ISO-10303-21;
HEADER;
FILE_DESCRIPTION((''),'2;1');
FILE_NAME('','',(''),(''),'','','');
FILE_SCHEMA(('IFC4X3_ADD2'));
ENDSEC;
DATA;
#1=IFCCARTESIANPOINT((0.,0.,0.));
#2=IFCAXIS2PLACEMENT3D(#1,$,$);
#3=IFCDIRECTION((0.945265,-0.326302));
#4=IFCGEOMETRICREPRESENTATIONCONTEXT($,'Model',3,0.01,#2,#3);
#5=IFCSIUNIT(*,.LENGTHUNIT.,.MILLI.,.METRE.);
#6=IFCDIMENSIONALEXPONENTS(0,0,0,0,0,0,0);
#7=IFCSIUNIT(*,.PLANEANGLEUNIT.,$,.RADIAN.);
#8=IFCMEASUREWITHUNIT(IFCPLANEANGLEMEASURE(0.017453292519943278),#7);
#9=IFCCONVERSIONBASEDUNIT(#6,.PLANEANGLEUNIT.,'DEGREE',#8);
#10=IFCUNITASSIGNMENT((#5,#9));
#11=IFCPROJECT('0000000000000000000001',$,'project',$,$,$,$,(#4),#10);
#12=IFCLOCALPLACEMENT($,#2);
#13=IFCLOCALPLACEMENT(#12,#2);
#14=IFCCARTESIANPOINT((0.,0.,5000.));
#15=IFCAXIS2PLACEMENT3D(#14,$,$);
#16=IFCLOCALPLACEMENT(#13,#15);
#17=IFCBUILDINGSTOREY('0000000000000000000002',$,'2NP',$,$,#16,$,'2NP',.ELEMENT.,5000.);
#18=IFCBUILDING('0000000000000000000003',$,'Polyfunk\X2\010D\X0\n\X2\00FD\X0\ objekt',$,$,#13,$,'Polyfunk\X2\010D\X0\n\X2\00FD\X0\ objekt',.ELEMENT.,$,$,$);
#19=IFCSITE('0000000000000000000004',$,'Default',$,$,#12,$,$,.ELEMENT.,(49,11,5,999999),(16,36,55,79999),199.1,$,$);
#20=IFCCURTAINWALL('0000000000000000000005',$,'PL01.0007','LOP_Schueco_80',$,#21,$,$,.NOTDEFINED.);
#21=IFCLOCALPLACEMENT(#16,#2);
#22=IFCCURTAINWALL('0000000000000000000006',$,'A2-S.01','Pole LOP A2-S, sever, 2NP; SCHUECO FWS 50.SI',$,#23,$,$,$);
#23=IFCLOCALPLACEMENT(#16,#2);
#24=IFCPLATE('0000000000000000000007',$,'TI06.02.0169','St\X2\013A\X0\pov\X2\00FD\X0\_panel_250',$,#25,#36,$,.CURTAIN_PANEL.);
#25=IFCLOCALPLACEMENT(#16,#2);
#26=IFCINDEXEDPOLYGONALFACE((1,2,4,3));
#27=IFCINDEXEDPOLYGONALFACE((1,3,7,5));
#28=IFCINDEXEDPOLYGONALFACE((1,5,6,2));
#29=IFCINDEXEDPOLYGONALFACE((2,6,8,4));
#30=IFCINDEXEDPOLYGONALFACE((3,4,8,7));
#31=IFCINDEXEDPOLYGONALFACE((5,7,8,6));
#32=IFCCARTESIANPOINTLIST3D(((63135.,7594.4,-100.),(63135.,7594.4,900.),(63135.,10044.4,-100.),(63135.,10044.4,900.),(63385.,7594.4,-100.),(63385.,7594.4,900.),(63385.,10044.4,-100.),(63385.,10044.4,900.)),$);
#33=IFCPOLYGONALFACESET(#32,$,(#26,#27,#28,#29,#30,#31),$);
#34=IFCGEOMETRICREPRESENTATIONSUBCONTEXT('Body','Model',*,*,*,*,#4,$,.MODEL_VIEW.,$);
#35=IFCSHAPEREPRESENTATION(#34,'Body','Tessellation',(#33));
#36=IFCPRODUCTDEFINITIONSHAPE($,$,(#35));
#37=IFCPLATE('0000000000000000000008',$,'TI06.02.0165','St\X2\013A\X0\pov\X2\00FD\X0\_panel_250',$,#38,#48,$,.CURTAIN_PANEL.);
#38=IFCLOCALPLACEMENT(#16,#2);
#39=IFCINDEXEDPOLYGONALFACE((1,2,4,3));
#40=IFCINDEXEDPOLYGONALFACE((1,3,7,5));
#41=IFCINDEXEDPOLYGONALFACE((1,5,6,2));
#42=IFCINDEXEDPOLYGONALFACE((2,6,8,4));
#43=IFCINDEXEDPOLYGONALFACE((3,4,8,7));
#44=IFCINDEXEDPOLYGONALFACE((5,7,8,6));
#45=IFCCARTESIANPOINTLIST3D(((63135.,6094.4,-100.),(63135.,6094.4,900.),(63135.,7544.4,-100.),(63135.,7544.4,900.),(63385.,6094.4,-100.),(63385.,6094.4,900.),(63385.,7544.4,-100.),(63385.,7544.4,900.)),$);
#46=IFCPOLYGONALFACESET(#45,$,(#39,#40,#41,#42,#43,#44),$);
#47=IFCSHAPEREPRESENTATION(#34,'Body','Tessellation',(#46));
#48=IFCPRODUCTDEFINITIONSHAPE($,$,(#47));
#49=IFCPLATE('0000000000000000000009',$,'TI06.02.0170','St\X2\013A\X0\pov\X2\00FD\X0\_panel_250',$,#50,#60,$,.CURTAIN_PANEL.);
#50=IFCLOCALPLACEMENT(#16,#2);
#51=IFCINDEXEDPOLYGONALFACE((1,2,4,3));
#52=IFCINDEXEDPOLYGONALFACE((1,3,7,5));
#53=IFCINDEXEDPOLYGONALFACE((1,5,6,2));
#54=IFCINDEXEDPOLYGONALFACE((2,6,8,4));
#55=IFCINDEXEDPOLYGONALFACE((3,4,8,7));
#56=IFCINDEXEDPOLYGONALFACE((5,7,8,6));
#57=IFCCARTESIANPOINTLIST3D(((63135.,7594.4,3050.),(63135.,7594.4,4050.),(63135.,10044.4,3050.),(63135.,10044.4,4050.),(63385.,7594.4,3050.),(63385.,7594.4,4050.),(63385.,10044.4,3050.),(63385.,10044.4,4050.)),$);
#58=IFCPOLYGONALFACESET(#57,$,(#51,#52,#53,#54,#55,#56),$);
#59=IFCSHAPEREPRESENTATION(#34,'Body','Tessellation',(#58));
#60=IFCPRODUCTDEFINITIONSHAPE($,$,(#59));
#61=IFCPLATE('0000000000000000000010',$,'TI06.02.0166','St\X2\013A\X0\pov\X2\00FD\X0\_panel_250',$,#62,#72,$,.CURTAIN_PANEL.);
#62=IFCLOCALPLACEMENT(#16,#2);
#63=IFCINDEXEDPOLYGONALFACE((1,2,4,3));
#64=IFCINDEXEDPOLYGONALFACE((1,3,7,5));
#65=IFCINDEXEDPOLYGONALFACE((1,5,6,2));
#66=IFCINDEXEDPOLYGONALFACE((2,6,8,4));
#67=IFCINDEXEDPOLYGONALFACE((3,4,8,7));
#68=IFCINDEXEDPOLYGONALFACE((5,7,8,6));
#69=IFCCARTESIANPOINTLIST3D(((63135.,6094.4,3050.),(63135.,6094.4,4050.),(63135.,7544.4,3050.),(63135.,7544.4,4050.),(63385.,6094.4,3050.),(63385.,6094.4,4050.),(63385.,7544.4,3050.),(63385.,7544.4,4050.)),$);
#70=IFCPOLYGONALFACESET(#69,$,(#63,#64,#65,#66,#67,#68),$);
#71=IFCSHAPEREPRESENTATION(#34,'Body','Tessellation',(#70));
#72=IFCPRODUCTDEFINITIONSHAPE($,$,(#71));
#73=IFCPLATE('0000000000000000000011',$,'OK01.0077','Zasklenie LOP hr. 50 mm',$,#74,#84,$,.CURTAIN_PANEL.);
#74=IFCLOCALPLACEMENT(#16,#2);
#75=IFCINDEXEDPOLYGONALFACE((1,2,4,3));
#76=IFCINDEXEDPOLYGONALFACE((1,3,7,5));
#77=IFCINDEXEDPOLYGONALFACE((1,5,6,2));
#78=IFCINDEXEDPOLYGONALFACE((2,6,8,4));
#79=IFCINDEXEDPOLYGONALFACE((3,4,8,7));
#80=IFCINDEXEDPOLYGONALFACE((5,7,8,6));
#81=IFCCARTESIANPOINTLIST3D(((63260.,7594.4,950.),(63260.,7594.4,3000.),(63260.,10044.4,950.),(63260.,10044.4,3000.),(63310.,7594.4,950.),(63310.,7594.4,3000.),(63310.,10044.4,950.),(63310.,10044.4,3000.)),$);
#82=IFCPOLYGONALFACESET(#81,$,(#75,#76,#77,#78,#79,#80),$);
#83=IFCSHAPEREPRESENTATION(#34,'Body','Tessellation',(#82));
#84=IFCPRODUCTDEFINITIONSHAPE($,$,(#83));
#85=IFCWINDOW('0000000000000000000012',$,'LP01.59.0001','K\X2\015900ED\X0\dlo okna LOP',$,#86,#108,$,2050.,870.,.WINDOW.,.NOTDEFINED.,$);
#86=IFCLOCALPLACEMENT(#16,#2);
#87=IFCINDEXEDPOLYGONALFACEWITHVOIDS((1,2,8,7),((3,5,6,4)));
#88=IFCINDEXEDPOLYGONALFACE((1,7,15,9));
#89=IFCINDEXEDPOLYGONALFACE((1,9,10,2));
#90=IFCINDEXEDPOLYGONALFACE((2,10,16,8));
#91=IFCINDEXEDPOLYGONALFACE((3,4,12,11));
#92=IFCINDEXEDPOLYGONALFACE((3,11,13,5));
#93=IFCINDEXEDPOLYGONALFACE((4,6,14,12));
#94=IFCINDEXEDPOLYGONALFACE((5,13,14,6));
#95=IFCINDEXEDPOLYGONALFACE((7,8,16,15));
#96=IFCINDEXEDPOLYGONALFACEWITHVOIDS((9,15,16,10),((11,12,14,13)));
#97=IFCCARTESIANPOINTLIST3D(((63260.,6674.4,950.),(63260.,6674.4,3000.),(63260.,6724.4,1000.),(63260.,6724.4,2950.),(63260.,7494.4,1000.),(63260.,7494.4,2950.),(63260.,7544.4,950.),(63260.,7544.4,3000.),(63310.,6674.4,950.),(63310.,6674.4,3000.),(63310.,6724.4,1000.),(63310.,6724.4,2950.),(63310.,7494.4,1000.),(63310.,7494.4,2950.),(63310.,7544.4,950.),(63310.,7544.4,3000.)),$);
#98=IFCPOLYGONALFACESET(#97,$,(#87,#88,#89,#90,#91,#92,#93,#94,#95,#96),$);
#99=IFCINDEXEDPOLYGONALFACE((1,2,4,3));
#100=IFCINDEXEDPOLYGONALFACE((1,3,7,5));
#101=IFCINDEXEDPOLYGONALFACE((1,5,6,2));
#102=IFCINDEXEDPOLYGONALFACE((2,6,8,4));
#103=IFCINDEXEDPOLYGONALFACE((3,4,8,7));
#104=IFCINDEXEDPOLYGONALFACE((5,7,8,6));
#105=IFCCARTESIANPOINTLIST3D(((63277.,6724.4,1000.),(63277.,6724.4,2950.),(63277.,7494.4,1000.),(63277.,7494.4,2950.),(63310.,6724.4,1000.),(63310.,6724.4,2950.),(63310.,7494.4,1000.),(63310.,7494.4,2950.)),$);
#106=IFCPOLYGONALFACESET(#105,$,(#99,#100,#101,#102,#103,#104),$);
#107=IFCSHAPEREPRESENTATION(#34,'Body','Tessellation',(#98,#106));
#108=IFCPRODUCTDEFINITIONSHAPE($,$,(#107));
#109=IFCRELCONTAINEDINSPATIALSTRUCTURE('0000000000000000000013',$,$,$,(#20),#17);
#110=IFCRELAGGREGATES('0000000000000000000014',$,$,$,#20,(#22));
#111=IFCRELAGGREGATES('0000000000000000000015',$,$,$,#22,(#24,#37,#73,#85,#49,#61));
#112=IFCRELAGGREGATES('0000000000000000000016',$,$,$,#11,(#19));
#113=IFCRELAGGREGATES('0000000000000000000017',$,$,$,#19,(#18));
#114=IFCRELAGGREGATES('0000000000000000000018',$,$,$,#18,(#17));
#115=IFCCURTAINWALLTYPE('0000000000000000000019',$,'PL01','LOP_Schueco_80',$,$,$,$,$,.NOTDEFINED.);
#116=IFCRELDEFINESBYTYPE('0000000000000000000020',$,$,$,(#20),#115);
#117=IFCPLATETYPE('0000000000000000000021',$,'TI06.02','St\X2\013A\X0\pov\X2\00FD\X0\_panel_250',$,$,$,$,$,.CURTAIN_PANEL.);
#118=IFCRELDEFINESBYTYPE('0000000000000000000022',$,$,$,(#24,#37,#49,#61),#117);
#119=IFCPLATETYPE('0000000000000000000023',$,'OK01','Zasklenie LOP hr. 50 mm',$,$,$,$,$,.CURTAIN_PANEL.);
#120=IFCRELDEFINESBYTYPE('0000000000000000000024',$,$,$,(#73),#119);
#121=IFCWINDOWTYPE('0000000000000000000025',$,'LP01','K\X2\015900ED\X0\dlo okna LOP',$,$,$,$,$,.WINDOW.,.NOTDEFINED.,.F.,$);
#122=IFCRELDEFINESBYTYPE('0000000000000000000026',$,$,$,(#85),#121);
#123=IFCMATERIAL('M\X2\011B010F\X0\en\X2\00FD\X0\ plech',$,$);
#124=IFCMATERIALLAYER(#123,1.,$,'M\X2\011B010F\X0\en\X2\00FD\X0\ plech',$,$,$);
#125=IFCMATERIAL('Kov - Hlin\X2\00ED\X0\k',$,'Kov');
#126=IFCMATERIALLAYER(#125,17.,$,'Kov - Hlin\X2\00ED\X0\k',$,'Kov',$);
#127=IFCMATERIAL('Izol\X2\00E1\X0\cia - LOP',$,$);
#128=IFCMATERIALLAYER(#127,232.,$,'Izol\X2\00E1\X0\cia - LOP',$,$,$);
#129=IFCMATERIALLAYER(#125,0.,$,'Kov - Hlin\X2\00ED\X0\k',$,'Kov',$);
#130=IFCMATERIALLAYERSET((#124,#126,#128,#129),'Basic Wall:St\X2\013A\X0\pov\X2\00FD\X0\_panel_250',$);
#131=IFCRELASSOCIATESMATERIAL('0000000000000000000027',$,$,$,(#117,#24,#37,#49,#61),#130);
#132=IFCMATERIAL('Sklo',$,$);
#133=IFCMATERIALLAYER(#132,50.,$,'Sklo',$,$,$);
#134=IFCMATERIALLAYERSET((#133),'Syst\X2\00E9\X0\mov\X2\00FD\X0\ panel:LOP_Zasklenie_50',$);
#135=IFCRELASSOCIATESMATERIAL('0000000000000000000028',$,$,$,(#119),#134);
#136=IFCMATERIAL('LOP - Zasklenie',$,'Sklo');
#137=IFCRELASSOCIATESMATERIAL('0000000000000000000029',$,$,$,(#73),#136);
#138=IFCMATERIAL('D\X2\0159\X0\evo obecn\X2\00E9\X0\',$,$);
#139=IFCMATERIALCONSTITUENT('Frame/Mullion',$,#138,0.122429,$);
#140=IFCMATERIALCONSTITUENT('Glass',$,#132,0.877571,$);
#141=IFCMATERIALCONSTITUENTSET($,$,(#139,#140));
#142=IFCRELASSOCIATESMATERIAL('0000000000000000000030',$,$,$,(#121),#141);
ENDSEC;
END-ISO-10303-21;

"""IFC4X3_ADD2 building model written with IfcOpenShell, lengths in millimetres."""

from ifc_helpers import new_model, entity, si_unit, converted_unit, direction, frame, frame_2d, origin, origin_2d_with_axis, place, context, subcontext, project, spatial, polyline, rectangle, outline, extrude, source, transform, mapped, material, layer, layer_set, layer_usage, constituent, constituent_set, type_object, type_shapes, element, aggregate, save


model = new_model("IFC4X3_ADD2")

# Units and contexts
model_context = context("Model", 3, precision=0.01, world=origin(), true_north=direction((0.945265, -0.326302)))
body_context = subcontext(model_context, "Body", "Model", "MODEL_VIEW")
ifc_project = project(units=[si_unit("LENGTHUNIT", "METRE", prefix="MILLI"), converted_unit("PLANEANGLEUNIT", "DEGREE", entity("IfcPlaneAngleMeasure", 0.017453292519943278), si_unit("PLANEANGLEUNIT", "RADIAN"), dimensions=[0, 0, 0, 0, 0, 0, 0])], contexts=[model_context])

# Site, building, storey
site_placement = place(None, origin())
site = spatial("IfcSite", under=ifc_project, at=site_placement, Name="Default", CompositionType="ELEMENT", RefLatitude=(49, 11, 5, 999999), RefLongitude=(16, 36, 55, 79999), RefElevation=199.1)
building_placement = place(site_placement, origin())
building = spatial("IfcBuilding", under=site, at=building_placement, Name="Polyfunkčný objekt", LongName="Polyfunkčný objekt", CompositionType="ELEMENT")
storey_placement = place(building_placement, frame((0.0, 0.0, 5000.0)))
storey = spatial("IfcBuildingStorey", under=building, at=storey_placement, Name="2NP", LongName="2NP", CompositionType="ELEMENT", Elevation=5000.0)

# Curtain walls, plates, window
curtain_wall_type = type_object("IfcCurtainWallType", Name="PL01", Description="LOP_Schueco_80", PredefinedType="NOTDEFINED")
curtain_wall_1_placement = place(storey_placement, frame((0.0, 0.0, -5000.0)))
curtain_wall_1 = element("IfcCurtainWall", 1, at=curtain_wall_1_placement, inside=storey, type_object=curtain_wall_type, Name="PL01.0007", Description="LOP_Schueco_80", PredefinedType="NOTDEFINED")
curtain_wall_2 = element("IfcCurtainWall", 2, Name="A2-S.01", Description="Pole LOP A2-S, sever, 2NP; SCHUECO FWS 50.SI")
aggregate(curtain_wall_1, [curtain_wall_2])
ifc_material_1 = material(Name="Měďený plech")
ifc_layer_1 = layer(ifc_material_1, 1.0, Name="Měďený plech")
ifc_material_2 = material(Name="Kov - Hliník", Category="Kov")
ifc_layer_2 = layer(ifc_material_2, 17.0, Name="Kov - Hliník", Category="Kov")
ifc_material_3 = material(Name="Izolácia - LOP")
ifc_layer_3 = layer(ifc_material_3, 232.0, Name="Izolácia - LOP")
ifc_layer_4 = layer(ifc_material_2, 0.0, Name="Kov - Hliník", Category="Kov")
ifc_layer_set_1 = layer_set([ifc_layer_1, ifc_layer_2, ifc_layer_3, ifc_layer_4], Name="Basic Wall:Stĺpový_panel_250")
ifc_layer_usage_1 = layer_usage(ifc_layer_set_1, "AXIS2", "NEGATIVE", 125.0)
plate_type_1 = type_object("IfcPlateType", Name="TI06.02", Description="Stĺpový_panel_250", PredefinedType="CURTAIN_PANEL", material=ifc_layer_set_1)
plate_1_placement = place(storey_placement, frame((63260.0, 10044.4, -100.0), z_axis=(0.0, 0.0, 1.0), x_axis=(0.0, -1.0, 0.0)))
plate_1 = element("IfcPlate", 3, at=plate_1_placement, type_object=plate_type_1, material=ifc_layer_usage_1, Name="TI06.02.0169", Description="Stĺpový_panel_250", PredefinedType="CURTAIN_PANEL", context=body_context, shape_type="SweptSolid", body=[
    extrude(rectangle(XDim=250.0, YDim=2450.0, at=origin_2d_with_axis()), frame((1225.0, 0.0, 0.0), z_axis=(0.0, 0.0, 1.0), x_axis=(0.0, 1.0, 0.0)), (0.0, 0.0, 1.0), 1000.0),
])
ifc_layer_usage_2 = layer_usage(ifc_layer_set_1, "AXIS2", "NEGATIVE", 125.0)
plate_2_placement = place(storey_placement, frame((63260.0, 7544.4, -100.0), z_axis=(0.0, 0.0, 1.0), x_axis=(0.0, -1.0, 0.0)))
plate_2 = element("IfcPlate", 4, at=plate_2_placement, type_object=plate_type_1, material=ifc_layer_usage_2, Name="TI06.02.0165", Description="Stĺpový_panel_250", PredefinedType="CURTAIN_PANEL", context=body_context, shape_type="SweptSolid", body=[
    extrude(rectangle(XDim=250.0, YDim=1450.0, at=frame_2d((0.0, 0.0), x_axis=(1.0, 0.0))), frame((725.0, 0.0, 0.0), z_axis=(0.0, 0.0, 1.0), x_axis=(0.0, 1.0, 0.0)), (0.0, 0.0, 1.0), 1000.0),
])
ifc_layer_usage_3 = layer_usage(ifc_layer_set_1, "AXIS2", "NEGATIVE", 125.0)
plate_3_placement = place(storey_placement, frame((63260.0, 10044.4, 3050.0), z_axis=(0.0, 0.0, 1.0), x_axis=(0.0, -1.0, 0.0)))
plate_3 = element("IfcPlate", 5, at=plate_3_placement, type_object=plate_type_1, material=ifc_layer_usage_3, Name="TI06.02.0170", Description="Stĺpový_panel_250", PredefinedType="CURTAIN_PANEL", context=body_context, shape_type="SweptSolid", body=[
    extrude(rectangle(XDim=250.0, YDim=2450.0, at=frame_2d((0.0, 0.0), x_axis=(1.0, 0.0))), frame((1225.0, 0.0, 0.0), z_axis=(0.0, 0.0, 1.0), x_axis=(0.0, 1.0, 0.0)), (0.0, 0.0, 1.0), 1000.0),
])
ifc_layer_usage_4 = layer_usage(ifc_layer_set_1, "AXIS2", "NEGATIVE", 125.0)
plate_4_placement = place(storey_placement, frame((63260.0, 7544.4, 3050.0), z_axis=(0.0, 0.0, 1.0), x_axis=(0.0, -1.0, 0.0)))
plate_4 = element("IfcPlate", 6, at=plate_4_placement, type_object=plate_type_1, material=ifc_layer_usage_4, Name="TI06.02.0166", Description="Stĺpový_panel_250", PredefinedType="CURTAIN_PANEL", context=body_context, shape_type="SweptSolid", body=[
    extrude(rectangle(XDim=250.0, YDim=1450.0, at=frame_2d((0.0, 0.0), x_axis=(1.0, 0.0))), frame((725.0, 0.0, 0.0), z_axis=(0.0, 0.0, 1.0), x_axis=(0.0, 1.0, 0.0)), (0.0, 0.0, 1.0), 1000.0),
])
ifc_material_4 = material(Name="LOP - Zasklenie", Category="Sklo")
ifc_material_5 = material(Name="Sklo")
ifc_layer_5 = layer(ifc_material_5, 50.0, Name="Sklo")
ifc_layer_set_2 = layer_set([ifc_layer_5], Name="Systémový panel:LOP_Zasklenie_50")
plate_type_2 = type_object("IfcPlateType", Name="OK01", Description="Zasklenie LOP hr. 50 mm", PredefinedType="CURTAIN_PANEL", material=ifc_layer_set_2)
shared_shape_1 = source(origin(), body_context, "Body", "SweptSolid", [
    extrude(rectangle(XDim=50.0, YDim=2450.0, at=origin_2d_with_axis()), frame((0.0, 25.0, 0.0), z_axis=(0.0, 0.0, 1.0), x_axis=(0.0, 1.0, 0.0)), (0.0, 0.0, 1.0), 2050.0),
])
type_shapes(plate_type_2, [shared_shape_1])
plate_5_placement = place(curtain_wall_1_placement, frame((63260.0, 8819.4, 5950.0), z_axis=(0.0, 0.0, 1.0), x_axis=(0.0, -1.0, 0.0)))
plate_5 = element("IfcPlate", 7, at=plate_5_placement, type_object=plate_type_2, material=ifc_material_4, Name="OK01.0077", Description="Zasklenie LOP hr. 50 mm", PredefinedType="CURTAIN_PANEL", context=body_context, shape_type="MappedRepresentation", body=[
    mapped(shared_shape_1, transform((0.0, 0.0, 0.0), scale=1.0)),
])
ifc_material_6 = material(Name="Dřevo obecné")
ifc_constituent_1 = constituent(ifc_material_6, Name="Frame/Mullion", fraction=0.122429)
ifc_constituent_2 = constituent(ifc_material_5, Name="Glass", fraction=0.877571)
ifc_constituent_set = constituent_set(constituents=[ifc_constituent_1, ifc_constituent_2])
window_type = type_object("IfcWindowType", Name="LP01", Description="Křídlo okna LOP", ParameterTakesPrecedence=False, PartitioningType="NOTDEFINED", PredefinedType="WINDOW", material=ifc_constituent_set)
shared_shape_2 = source(origin(), body_context, "Body", "SweptSolid", [
    extrude(outline(polyline([(-1025.0, -435.0), (1025.0, -435.0), (1025.0, 435.0), (-1025.0, 435.0), (-1025.0, -435.0)]), holes=[polyline([(-975.0, -385.0), (-975.0, 385.0), (975.0, 385.0), (975.0, -385.0), (-975.0, -385.0)])]), frame((0.0, 0.0, 1025.0), z_axis=(0.0, 1.0, 0.0), x_axis=(0.0, 0.0, -1.0)), (0.0, 0.0, 1.0), 50.0),
    extrude(rectangle(XDim=33.0, YDim=770.0, at=origin_2d_with_axis()), frame((0.0, 33.5, 50.0), z_axis=(0.0, 0.0, 1.0), x_axis=(0.0, -1.0, 0.0)), (0.0, 0.0, 1.0), 1950.0),
])
type_shapes(window_type, [shared_shape_2])
window_placement = place(curtain_wall_1_placement, frame((63260.0, 7109.4, 5950.0), z_axis=(0.0, 0.0, 1.0), x_axis=(0.0, -1.0, 0.0)))
window = element("IfcWindow", 8, at=window_placement, type_object=window_type, Name="LP01.59.0001", Description="Křídlo okna LOP", OverallHeight=2050.0, OverallWidth=870.0, PartitioningType="NOTDEFINED", PredefinedType="WINDOW", context=body_context, shape_type="MappedRepresentation", body=[
    mapped(shared_shape_2, transform((0.0, 0.0, 0.0), scale=1.0)),
])
aggregate(curtain_wall_2, [plate_1, plate_2, plate_5, window, plate_3, plate_4])

save(model, "model.ifc")
